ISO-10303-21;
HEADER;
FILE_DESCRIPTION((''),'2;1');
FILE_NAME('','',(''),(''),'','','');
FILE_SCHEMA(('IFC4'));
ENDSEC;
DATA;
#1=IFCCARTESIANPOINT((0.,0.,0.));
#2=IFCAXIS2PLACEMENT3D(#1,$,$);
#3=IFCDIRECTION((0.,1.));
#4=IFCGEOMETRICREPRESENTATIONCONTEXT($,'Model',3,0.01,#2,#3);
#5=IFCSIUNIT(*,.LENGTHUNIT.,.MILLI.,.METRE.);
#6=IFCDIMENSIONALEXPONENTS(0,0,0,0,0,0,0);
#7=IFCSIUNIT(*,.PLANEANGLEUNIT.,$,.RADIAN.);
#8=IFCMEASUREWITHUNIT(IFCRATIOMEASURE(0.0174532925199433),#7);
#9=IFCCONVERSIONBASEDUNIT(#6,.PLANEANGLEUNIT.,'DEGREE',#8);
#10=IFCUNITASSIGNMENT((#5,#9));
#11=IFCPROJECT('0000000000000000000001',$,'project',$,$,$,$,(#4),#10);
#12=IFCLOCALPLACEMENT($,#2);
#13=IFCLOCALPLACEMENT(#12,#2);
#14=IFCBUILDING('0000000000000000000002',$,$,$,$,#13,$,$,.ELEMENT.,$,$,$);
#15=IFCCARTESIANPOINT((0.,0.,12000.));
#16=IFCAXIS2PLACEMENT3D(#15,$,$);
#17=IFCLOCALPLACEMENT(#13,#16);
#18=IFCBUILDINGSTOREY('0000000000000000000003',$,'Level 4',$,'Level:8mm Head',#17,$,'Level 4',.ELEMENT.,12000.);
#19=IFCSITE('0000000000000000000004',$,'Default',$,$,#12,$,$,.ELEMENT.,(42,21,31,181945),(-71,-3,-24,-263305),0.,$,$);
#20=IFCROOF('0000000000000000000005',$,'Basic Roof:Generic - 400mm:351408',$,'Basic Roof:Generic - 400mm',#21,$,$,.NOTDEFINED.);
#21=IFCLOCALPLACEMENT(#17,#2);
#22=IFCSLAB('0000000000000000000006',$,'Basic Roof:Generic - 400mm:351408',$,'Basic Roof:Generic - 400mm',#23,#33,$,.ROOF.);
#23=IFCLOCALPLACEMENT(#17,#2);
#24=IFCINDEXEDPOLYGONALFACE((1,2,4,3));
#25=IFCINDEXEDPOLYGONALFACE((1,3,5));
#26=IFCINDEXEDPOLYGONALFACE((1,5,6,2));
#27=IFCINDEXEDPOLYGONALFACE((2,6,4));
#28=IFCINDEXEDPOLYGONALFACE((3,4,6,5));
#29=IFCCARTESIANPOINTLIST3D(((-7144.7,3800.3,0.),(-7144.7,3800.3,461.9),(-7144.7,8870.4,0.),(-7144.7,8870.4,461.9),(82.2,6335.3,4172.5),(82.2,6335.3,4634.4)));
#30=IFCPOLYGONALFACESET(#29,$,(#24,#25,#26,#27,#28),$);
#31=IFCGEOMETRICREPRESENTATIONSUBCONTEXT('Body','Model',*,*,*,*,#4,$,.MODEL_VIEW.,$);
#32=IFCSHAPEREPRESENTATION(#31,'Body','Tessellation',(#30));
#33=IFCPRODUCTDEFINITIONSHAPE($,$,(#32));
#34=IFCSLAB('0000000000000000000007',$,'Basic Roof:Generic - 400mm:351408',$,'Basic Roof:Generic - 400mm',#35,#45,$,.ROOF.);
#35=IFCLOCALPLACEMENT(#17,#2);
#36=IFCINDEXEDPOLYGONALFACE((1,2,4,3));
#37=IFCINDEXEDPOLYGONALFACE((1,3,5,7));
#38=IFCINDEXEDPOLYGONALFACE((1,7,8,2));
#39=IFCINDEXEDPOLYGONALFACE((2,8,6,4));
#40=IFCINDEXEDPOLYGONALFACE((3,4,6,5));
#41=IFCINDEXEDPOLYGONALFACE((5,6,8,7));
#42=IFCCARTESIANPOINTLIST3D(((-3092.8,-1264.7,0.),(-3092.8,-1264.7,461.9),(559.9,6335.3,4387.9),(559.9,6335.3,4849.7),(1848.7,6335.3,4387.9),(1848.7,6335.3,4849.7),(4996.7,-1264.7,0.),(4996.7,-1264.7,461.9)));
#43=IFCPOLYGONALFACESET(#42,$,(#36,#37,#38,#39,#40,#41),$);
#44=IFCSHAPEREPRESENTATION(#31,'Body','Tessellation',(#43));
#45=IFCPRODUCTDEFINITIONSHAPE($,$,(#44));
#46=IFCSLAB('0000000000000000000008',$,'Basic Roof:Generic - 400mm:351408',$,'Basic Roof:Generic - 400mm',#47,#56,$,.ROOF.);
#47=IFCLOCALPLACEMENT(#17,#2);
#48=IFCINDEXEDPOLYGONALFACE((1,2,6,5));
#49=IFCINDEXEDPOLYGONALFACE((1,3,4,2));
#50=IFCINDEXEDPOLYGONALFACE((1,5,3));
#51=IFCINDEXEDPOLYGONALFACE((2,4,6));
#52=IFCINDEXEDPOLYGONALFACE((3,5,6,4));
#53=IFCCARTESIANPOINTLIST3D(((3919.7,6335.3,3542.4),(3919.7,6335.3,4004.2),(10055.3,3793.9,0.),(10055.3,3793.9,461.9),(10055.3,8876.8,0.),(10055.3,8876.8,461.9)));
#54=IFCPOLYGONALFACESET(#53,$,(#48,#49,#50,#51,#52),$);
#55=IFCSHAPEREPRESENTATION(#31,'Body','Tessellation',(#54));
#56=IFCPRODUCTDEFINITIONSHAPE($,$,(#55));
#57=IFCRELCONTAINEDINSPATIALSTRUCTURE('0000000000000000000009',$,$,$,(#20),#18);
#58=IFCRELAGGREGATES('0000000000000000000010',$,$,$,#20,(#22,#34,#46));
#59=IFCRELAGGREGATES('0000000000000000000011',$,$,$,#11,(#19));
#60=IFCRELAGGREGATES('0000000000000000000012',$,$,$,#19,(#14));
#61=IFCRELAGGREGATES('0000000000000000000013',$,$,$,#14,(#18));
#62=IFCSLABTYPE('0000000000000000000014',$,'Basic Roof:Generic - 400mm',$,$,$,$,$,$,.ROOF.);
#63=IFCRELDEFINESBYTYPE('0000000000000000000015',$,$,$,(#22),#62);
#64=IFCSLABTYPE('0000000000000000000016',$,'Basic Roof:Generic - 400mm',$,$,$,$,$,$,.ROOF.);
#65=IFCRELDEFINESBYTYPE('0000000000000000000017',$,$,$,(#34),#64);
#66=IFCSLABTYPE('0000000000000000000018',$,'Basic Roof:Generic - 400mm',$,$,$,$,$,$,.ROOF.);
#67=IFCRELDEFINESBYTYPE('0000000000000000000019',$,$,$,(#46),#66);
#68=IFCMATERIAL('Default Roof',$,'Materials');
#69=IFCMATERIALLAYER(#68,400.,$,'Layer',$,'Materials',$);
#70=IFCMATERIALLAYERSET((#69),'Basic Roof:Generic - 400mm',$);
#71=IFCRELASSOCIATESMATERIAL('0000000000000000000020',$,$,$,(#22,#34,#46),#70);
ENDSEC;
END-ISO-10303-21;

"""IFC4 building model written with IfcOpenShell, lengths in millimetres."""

from ifc_helpers import new_model, entity, si_unit, converted_unit, direction, frame, origin, place, context, subcontext, project, spatial, polyline, outline, extrude, material, layer, layer_set, type_object, element, aggregate, save


model = new_model("IFC4")

# Units and contexts
model_context = context("Model", 3, precision=0.01, world=origin(), true_north=direction((0.0, 1.0)))
body_context = subcontext(model_context, "Body", "Model", "MODEL_VIEW")
ifc_project = project(units=[si_unit("LENGTHUNIT", "METRE", prefix="MILLI"), converted_unit("PLANEANGLEUNIT", "DEGREE", entity("IfcRatioMeasure", 0.0174532925199433), si_unit("PLANEANGLEUNIT", "RADIAN"), dimensions=[0, 0, 0, 0, 0, 0, 0])], contexts=[model_context])

# Site, building, storey
site_placement = place(None, origin())
site = spatial("IfcSite", under=ifc_project, at=site_placement, Name="Default", CompositionType="ELEMENT", RefLatitude=(42, 21, 31, 181945), RefLongitude=(-71, -3, -24, -263305), RefElevation=0.0)
building_placement = place(site_placement, origin())
building = spatial("IfcBuilding", under=site, at=building_placement, CompositionType="ELEMENT")
storey_placement = place(building_placement, frame((0.0, 0.0, 12000.0)))
storey = spatial("IfcBuildingStorey", under=building, at=storey_placement, Name="Level 4", ObjectType="Level:8mm Head", LongName="Level 4", CompositionType="ELEMENT", Elevation=12000.0)

# Roof, slabs
roof_placement = place(storey_placement, frame((-7144.7, -1264.7, 0.0)))
roof = element("IfcRoof", 1, at=roof_placement, inside=storey, Name="Basic Roof:Generic - 400mm:351408", ObjectType="Basic Roof:Generic - 400mm", PredefinedType="NOTDEFINED")
ifc_material = material(Name="Default Roof", Category="Materials")
ifc_layer = layer(ifc_material, 400.0, Name="Layer", Category="Materials")
ifc_layer_set = layer_set([ifc_layer], Name="Basic Roof:Generic - 400mm")
slab_type_1 = type_object("IfcSlabType", Name="Basic Roof:Generic - 400mm", PredefinedType="ROOF")
slab_1_placement = place(roof_placement, origin())
slab_1 = element("IfcSlab", 2, at=slab_1_placement, type_object=slab_type_1, material=ifc_layer_set, Name="Basic Roof:Generic - 400mm:351408", ObjectType="Basic Roof:Generic - 400mm", PredefinedType="ROOF", context=body_context, shape_type="SweptSolid", body=[
    extrude(outline(polyline([(-4172.5, 2535.1), (-4172.5, -2535.1), (4172.5, 0.0), (-4172.5, 2535.1)])), frame((3613.5, 7600.0, 2086.2), z_axis=(-0.5, 0.0, 0.866025), x_axis=(0.866025, 0.0, 0.5)), (0.5, 0.0, 0.866025), 461.9),
])
slab_type_2 = type_object("IfcSlabType", Name="Basic Roof:Generic - 400mm", PredefinedType="ROOF")
slab_2_placement = place(roof_placement, origin())
slab_2 = element("IfcSlab", 3, at=slab_2_placement, type_object=slab_type_2, material=ifc_layer_set, Name="Basic Roof:Generic - 400mm:351408", ObjectType="Basic Roof:Generic - 400mm", PredefinedType="ROOF", context=body_context, shape_type="SweptSolid", body=[
    extrude(outline(polyline([(-4044.7, -4387.9), (4044.7, -4387.9), (896.7, 4387.9), (-392.0, 4387.9), (-4044.7, -4387.9)])), frame((8096.7, 3800.0, 2193.9), z_axis=(0.0, -0.5, 0.866025), x_axis=(1.0, 0.0, 0.0)), (0.0, 0.5, 0.866025), 461.9),
])
slab_type_3 = type_object("IfcSlabType", Name="Basic Roof:Generic - 400mm", PredefinedType="ROOF")
slab_3_placement = place(roof_placement, origin())
slab_3 = element("IfcSlab", 4, at=slab_3_placement, type_object=slab_type_3, material=ifc_layer_set, Name="Basic Roof:Generic - 400mm:351408", ObjectType="Basic Roof:Generic - 400mm", PredefinedType="ROOF", context=body_context, shape_type="SweptSolid", body=[
    extrude(outline(polyline([(3542.4, -2541.4), (3542.4, 2541.4), (-3542.4, 0.0), (3542.4, -2541.4)])), frame((14132.2, 7600.0, 1771.2), z_axis=(0.5, 0.0, 0.866025), x_axis=(0.866025, 0.0, -0.5)), (-0.5, 0.0, 0.866025), 461.9),
])
aggregate(roof, [slab_1, slab_2, slab_3])

save(model, "model.ifc")
